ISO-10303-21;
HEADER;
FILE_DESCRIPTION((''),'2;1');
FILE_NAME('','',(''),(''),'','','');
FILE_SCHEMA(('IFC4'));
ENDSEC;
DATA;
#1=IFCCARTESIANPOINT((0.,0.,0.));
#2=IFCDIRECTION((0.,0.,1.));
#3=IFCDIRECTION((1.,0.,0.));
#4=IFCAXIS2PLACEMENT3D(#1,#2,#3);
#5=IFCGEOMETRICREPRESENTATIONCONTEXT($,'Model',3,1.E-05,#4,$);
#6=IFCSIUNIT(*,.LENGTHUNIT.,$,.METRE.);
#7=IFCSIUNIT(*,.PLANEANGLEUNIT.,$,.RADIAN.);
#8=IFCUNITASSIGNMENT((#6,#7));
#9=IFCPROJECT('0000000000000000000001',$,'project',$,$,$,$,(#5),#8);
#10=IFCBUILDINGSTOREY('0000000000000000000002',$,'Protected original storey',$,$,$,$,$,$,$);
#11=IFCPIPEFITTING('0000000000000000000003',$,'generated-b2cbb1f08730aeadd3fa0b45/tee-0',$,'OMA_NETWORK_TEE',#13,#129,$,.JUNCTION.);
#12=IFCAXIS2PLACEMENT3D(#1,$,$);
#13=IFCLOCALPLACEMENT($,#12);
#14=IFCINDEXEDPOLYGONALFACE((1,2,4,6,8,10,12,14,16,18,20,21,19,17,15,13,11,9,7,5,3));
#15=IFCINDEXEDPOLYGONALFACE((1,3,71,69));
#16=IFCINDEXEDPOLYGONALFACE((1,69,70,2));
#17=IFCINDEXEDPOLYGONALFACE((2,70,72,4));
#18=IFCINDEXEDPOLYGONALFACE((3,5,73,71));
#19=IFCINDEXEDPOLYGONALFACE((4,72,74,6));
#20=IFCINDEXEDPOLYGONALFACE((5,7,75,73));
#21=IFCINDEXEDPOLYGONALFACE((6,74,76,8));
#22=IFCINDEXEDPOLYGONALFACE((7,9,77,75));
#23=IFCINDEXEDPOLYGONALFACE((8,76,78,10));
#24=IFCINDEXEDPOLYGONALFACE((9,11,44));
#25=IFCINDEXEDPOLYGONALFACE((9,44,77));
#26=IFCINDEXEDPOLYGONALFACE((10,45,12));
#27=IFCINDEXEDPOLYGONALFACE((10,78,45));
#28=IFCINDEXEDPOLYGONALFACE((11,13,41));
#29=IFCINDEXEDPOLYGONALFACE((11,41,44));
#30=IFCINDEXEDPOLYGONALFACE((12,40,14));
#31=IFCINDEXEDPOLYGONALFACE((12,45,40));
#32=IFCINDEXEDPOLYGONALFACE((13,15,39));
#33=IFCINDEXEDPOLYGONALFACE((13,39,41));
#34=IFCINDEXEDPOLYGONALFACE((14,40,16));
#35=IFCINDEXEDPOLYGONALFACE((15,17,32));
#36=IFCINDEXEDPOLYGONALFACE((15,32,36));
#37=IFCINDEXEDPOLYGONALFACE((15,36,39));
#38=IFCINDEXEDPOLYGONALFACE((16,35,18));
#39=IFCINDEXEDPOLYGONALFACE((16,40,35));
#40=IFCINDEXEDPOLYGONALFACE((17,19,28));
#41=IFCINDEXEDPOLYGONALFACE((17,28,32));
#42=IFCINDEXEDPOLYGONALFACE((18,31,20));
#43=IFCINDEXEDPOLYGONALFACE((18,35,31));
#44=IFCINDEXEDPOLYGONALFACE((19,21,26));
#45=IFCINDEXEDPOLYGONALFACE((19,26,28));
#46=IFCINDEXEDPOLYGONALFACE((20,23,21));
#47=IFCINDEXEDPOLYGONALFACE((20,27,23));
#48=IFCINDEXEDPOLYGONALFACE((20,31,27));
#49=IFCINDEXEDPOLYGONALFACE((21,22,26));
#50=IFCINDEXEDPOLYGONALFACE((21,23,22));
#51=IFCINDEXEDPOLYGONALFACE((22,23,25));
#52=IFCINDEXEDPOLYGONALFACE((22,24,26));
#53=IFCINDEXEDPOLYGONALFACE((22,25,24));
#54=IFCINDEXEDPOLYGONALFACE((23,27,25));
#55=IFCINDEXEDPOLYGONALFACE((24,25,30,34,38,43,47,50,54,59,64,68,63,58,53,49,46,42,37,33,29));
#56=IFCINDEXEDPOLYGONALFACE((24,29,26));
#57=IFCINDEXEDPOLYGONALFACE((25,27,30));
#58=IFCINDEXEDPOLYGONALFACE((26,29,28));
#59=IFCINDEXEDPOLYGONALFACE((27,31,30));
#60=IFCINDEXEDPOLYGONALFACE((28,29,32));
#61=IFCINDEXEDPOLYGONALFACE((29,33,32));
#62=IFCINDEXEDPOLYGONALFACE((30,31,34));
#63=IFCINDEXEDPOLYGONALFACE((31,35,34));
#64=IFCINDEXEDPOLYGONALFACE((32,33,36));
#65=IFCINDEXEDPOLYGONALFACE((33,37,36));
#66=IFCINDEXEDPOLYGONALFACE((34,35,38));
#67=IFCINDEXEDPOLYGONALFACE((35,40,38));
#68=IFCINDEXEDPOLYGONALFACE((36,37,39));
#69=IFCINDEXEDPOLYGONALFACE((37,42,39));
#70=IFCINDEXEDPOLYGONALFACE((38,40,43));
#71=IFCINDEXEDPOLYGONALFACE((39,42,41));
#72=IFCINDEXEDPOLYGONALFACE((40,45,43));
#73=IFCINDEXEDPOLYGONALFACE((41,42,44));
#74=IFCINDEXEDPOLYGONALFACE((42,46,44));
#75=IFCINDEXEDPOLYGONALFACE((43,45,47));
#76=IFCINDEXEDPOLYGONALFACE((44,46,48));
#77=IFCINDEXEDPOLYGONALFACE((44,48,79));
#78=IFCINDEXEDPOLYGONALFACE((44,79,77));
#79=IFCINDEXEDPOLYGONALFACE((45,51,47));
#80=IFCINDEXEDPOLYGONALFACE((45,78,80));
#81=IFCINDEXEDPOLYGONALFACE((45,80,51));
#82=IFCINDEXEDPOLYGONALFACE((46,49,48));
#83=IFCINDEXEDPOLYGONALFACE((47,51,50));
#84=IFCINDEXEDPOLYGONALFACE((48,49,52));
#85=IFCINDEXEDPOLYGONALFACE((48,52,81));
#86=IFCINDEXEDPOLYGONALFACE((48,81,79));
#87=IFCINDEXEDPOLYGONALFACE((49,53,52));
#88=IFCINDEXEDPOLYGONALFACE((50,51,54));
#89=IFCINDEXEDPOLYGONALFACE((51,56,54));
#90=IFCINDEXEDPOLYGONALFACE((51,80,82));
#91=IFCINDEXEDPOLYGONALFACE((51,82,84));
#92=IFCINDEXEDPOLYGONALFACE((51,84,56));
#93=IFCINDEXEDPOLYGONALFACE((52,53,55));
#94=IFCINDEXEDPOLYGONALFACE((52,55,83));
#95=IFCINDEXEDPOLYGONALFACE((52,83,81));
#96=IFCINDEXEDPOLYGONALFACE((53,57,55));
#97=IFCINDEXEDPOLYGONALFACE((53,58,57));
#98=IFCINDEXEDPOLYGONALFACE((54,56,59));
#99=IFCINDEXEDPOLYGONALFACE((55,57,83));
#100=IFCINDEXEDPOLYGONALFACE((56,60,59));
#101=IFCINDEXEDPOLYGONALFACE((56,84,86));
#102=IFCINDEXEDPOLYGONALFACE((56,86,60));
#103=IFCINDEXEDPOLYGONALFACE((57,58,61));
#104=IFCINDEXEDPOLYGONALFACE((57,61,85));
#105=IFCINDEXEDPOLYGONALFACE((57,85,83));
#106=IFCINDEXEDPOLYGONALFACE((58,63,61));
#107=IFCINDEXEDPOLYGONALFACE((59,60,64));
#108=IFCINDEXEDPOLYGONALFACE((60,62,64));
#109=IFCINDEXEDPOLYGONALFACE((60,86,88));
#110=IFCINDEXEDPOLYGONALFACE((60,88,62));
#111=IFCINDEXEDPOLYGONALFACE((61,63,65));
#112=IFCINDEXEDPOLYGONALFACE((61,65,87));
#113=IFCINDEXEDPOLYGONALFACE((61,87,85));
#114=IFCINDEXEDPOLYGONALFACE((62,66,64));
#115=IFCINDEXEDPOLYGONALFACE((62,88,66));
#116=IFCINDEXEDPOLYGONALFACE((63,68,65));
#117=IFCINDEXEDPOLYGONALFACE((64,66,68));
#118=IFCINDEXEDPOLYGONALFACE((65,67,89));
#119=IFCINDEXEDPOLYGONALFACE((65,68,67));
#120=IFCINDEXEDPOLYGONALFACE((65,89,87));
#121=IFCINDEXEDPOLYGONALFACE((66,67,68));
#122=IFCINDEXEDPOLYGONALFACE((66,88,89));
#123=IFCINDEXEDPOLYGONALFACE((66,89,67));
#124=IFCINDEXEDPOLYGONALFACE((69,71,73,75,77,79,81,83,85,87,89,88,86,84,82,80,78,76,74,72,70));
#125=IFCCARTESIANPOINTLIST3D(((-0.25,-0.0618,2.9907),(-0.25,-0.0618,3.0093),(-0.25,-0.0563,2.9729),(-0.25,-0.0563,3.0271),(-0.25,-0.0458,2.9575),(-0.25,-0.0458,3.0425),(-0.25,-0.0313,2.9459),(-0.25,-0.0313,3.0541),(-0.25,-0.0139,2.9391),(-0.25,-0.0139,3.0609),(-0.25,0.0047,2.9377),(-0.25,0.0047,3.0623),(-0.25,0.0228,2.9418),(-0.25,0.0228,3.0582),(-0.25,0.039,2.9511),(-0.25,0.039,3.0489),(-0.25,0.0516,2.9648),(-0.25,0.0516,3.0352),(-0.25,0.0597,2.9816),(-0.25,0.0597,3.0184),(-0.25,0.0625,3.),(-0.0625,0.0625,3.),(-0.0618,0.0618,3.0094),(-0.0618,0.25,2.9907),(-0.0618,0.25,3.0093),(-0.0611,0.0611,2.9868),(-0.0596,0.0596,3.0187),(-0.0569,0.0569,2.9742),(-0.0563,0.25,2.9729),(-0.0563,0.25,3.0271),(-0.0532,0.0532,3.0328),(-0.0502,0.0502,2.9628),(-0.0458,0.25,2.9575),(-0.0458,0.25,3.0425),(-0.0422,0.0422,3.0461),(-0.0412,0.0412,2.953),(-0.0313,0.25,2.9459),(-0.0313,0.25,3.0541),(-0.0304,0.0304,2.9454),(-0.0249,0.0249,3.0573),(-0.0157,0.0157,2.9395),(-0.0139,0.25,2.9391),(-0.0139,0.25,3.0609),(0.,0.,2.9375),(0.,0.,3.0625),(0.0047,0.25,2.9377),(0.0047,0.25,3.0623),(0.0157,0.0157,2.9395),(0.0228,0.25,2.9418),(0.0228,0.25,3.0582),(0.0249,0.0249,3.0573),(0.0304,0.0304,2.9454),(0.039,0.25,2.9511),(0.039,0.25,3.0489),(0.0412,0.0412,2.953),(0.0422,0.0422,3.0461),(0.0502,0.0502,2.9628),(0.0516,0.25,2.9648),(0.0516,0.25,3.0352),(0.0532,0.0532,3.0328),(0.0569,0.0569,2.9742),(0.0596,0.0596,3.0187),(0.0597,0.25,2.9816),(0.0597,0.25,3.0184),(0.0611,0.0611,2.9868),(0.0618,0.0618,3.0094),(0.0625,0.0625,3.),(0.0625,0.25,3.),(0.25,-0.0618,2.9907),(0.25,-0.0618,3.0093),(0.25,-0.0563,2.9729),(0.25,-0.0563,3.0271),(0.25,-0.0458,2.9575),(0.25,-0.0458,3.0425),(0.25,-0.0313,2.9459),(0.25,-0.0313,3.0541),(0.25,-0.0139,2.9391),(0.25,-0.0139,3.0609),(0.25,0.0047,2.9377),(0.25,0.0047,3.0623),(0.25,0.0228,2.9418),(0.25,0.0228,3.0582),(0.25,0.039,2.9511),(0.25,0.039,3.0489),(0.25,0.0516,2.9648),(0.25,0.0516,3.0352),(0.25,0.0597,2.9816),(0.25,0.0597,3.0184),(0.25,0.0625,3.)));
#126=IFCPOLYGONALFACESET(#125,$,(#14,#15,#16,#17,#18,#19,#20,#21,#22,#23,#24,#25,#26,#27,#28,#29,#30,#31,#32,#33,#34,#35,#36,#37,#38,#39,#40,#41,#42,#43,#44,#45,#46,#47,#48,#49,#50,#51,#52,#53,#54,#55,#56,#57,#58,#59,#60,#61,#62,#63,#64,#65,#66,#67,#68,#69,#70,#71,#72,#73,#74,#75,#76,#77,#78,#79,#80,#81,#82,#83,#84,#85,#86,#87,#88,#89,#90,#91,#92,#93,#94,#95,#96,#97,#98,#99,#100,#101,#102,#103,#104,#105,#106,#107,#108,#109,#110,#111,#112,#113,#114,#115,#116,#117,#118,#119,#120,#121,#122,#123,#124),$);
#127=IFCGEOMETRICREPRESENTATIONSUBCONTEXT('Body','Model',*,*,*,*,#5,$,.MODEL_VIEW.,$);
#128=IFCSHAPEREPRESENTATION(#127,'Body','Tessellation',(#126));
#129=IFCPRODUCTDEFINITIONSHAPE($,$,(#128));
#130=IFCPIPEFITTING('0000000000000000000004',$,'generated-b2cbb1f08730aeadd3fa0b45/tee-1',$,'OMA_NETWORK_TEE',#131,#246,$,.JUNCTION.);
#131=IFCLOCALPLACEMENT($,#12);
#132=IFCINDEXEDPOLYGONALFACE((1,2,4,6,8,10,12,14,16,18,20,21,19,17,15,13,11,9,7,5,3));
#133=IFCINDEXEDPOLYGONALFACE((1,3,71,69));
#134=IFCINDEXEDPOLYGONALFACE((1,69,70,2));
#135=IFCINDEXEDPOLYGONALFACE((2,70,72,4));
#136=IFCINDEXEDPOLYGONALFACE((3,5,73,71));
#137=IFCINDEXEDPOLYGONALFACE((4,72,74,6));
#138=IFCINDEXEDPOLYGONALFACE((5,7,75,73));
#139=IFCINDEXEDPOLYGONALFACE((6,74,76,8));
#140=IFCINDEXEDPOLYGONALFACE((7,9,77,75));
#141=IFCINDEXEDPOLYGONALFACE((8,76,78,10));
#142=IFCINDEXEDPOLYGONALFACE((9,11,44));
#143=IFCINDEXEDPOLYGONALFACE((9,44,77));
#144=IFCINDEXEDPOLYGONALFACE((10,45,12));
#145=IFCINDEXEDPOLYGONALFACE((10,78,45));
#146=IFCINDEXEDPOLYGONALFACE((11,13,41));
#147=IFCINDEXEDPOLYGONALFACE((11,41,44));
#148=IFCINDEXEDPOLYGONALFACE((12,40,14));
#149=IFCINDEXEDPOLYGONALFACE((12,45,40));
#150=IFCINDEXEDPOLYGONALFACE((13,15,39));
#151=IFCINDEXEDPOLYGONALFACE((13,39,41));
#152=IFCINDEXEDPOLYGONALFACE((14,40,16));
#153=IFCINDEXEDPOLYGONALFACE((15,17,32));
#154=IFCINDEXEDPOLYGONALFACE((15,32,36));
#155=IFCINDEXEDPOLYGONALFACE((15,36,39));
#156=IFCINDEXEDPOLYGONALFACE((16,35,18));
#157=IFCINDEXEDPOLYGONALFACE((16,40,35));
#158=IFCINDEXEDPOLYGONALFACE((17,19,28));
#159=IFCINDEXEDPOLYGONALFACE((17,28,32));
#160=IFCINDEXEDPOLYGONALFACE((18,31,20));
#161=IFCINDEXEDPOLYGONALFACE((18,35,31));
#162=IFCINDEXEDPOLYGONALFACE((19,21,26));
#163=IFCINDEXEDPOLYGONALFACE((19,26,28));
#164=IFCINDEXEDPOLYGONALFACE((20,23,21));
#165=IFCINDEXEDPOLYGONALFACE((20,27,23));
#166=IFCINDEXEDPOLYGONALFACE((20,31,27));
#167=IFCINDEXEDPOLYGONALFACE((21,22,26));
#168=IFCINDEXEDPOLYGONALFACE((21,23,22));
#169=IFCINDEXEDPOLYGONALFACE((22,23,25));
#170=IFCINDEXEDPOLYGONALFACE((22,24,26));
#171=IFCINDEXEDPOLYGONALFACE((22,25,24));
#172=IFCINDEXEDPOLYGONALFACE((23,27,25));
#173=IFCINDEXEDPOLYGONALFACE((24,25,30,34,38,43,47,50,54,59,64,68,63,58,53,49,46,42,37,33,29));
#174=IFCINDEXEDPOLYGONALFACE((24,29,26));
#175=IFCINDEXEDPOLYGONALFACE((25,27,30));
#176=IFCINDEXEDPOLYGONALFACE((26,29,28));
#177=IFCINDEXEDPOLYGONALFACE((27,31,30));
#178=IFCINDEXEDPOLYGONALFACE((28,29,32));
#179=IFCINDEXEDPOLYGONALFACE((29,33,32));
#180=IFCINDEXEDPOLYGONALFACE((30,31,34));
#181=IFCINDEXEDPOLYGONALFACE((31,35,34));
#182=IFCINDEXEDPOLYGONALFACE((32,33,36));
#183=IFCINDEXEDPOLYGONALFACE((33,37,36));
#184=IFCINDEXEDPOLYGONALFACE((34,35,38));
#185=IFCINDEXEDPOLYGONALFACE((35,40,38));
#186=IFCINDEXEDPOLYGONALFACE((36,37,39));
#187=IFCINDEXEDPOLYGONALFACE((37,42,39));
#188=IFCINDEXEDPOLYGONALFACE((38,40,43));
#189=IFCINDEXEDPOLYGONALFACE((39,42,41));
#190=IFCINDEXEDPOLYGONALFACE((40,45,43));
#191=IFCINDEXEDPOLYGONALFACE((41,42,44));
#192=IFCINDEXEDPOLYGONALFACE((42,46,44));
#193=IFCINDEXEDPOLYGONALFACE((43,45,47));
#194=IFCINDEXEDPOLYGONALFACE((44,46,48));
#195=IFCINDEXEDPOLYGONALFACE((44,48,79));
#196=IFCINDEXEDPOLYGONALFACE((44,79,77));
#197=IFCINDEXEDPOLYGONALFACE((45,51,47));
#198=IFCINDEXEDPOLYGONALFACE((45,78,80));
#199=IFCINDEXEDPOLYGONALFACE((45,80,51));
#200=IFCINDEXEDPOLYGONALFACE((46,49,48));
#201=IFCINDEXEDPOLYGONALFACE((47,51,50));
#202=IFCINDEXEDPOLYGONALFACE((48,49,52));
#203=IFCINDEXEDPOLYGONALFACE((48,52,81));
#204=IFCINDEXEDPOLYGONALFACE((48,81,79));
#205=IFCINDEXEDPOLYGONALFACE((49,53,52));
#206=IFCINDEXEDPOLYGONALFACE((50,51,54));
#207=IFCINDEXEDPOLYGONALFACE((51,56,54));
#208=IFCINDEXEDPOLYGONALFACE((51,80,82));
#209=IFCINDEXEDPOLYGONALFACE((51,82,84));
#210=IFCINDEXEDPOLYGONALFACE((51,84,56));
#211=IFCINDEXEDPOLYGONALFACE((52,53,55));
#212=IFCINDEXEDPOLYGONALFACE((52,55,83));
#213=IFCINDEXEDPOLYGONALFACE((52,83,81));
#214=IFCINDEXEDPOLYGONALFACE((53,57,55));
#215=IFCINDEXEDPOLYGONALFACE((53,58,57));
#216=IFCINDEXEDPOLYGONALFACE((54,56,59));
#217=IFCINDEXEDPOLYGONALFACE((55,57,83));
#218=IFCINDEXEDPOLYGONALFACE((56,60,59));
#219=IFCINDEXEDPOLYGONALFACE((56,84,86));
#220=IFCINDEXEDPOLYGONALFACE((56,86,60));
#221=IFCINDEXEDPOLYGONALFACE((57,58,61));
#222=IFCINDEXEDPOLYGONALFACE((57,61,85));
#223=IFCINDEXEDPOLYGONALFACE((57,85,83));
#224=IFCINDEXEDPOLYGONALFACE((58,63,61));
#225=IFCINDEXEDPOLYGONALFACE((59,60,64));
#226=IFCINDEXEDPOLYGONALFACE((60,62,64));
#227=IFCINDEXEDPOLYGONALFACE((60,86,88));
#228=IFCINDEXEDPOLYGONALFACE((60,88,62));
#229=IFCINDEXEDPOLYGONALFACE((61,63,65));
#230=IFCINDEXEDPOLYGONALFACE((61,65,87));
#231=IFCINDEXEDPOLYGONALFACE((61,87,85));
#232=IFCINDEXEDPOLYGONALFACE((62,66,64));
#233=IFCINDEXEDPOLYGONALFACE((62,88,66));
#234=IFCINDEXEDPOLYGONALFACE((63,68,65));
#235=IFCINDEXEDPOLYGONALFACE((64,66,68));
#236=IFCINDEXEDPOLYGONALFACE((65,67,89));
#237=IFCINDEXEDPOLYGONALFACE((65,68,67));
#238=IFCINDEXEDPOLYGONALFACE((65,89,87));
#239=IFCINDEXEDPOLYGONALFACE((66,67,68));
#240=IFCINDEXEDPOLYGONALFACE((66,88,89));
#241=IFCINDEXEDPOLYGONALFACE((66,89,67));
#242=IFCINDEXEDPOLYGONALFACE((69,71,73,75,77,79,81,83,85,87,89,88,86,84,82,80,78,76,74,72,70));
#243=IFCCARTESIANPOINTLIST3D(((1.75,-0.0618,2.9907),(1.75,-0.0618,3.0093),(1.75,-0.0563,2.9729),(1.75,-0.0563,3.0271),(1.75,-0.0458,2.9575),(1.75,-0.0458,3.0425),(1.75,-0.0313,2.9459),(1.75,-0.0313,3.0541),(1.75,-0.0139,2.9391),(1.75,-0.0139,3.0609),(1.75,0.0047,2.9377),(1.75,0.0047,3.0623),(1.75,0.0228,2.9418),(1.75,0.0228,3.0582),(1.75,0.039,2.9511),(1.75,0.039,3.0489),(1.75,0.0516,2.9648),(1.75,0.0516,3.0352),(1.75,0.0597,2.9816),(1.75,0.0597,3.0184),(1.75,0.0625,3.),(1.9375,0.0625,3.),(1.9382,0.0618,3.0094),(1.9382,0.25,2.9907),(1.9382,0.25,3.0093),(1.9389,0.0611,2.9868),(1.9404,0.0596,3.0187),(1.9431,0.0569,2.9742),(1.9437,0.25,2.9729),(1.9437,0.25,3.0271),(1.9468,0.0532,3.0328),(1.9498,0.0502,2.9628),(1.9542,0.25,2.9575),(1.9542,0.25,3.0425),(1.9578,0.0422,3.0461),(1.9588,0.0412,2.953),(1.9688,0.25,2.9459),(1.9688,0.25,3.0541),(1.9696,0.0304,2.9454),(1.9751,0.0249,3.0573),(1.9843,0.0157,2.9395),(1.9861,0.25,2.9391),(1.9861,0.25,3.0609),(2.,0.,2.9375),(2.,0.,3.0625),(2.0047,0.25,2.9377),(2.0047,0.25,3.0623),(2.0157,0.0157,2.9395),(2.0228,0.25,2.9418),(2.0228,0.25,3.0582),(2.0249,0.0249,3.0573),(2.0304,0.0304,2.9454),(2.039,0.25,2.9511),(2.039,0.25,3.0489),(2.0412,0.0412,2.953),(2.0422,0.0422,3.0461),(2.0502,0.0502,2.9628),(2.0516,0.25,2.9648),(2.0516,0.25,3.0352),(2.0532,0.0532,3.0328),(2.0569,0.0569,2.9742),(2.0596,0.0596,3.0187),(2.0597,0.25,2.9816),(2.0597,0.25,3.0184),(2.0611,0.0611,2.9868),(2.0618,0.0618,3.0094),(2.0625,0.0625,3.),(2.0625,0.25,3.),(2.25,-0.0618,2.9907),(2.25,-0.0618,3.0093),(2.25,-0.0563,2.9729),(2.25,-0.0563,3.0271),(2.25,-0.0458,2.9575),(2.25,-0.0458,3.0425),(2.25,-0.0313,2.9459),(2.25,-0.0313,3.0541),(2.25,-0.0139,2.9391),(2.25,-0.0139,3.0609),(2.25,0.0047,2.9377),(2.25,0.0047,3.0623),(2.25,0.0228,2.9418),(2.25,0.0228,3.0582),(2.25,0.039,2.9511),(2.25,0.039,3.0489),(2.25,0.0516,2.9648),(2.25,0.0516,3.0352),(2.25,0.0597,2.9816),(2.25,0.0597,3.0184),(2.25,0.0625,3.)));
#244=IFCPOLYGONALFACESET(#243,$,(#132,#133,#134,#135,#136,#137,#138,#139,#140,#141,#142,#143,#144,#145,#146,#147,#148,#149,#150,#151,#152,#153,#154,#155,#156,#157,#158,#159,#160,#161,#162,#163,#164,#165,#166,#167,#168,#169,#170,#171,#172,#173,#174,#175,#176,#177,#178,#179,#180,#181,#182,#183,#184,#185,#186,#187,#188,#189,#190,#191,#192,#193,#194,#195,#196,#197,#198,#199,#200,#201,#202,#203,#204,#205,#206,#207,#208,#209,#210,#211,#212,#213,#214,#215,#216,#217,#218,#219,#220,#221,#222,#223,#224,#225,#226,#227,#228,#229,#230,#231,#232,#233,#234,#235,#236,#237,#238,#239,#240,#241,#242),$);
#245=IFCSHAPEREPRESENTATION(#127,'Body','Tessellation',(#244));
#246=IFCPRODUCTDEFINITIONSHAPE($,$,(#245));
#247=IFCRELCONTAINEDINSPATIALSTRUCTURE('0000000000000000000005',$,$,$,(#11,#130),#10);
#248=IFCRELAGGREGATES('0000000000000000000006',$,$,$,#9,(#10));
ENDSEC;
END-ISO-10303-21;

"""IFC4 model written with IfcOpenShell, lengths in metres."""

from ifc_helpers import new_model, si_unit, frame, origin_with_axes, origin_2d, place, context, subcontext, project, spatial, circle, extrude, boolean, element, save


model = new_model("IFC4")

# Units and contexts
model_context = context("Model", 3, precision=1e-05, world=origin_with_axes())
body_context = subcontext(model_context, "Body", "Model", "MODEL_VIEW")
ifc_project = project(units=[si_unit("LENGTHUNIT", "METRE"), si_unit("PLANEANGLEUNIT", "RADIAN")], contexts=[model_context])

# Storey
storey = spatial("IfcBuildingStorey", under=ifc_project, Name="Protected original storey")

# Pipe fittings
pipe_fitting_1_placement = place(None, origin_with_axes())
element("IfcPipeFitting", 1, at=pipe_fitting_1_placement, inside=storey, Name="generated-b2cbb1f08730aeadd3fa0b45/tee-0", ObjectType="OMA_NETWORK_TEE", PredefinedType="JUNCTION", context=body_context, shape_type="CSG", body=[
    boolean("UNION", extrude(circle(Radius=0.0625, at=origin_2d()), frame((-0.25, 0.0, 3.0), z_axis=(1.0, 0.0, 0.0), x_axis=(0.0, 1.0, 0.0)), (0.0, 0.0, 1.0), 0.5), extrude(circle(Radius=0.0625, at=origin_2d()), frame((0.0, 0.0, 3.0), z_axis=(0.0, 1.0, 0.0), x_axis=(1.0, 0.0, 0.0)), (0.0, 0.0, 1.0), 0.25)),
])
pipe_fitting_2_placement = place(None, origin_with_axes())
element("IfcPipeFitting", 2, at=pipe_fitting_2_placement, inside=storey, Name="generated-b2cbb1f08730aeadd3fa0b45/tee-1", ObjectType="OMA_NETWORK_TEE", PredefinedType="JUNCTION", context=body_context, shape_type="CSG", body=[
    boolean("UNION", extrude(circle(Radius=0.0625, at=origin_2d()), frame((1.75, 0.0, 3.0), z_axis=(1.0, 0.0, 0.0), x_axis=(0.0, 1.0, 0.0)), (0.0, 0.0, 1.0), 0.5), extrude(circle(Radius=0.0625, at=origin_2d()), frame((2.0, 0.0, 3.0), z_axis=(0.0, 1.0, 0.0), x_axis=(1.0, 0.0, 0.0)), (0.0, 0.0, 1.0), 0.25)),
])

save(model, "model.ifc")
